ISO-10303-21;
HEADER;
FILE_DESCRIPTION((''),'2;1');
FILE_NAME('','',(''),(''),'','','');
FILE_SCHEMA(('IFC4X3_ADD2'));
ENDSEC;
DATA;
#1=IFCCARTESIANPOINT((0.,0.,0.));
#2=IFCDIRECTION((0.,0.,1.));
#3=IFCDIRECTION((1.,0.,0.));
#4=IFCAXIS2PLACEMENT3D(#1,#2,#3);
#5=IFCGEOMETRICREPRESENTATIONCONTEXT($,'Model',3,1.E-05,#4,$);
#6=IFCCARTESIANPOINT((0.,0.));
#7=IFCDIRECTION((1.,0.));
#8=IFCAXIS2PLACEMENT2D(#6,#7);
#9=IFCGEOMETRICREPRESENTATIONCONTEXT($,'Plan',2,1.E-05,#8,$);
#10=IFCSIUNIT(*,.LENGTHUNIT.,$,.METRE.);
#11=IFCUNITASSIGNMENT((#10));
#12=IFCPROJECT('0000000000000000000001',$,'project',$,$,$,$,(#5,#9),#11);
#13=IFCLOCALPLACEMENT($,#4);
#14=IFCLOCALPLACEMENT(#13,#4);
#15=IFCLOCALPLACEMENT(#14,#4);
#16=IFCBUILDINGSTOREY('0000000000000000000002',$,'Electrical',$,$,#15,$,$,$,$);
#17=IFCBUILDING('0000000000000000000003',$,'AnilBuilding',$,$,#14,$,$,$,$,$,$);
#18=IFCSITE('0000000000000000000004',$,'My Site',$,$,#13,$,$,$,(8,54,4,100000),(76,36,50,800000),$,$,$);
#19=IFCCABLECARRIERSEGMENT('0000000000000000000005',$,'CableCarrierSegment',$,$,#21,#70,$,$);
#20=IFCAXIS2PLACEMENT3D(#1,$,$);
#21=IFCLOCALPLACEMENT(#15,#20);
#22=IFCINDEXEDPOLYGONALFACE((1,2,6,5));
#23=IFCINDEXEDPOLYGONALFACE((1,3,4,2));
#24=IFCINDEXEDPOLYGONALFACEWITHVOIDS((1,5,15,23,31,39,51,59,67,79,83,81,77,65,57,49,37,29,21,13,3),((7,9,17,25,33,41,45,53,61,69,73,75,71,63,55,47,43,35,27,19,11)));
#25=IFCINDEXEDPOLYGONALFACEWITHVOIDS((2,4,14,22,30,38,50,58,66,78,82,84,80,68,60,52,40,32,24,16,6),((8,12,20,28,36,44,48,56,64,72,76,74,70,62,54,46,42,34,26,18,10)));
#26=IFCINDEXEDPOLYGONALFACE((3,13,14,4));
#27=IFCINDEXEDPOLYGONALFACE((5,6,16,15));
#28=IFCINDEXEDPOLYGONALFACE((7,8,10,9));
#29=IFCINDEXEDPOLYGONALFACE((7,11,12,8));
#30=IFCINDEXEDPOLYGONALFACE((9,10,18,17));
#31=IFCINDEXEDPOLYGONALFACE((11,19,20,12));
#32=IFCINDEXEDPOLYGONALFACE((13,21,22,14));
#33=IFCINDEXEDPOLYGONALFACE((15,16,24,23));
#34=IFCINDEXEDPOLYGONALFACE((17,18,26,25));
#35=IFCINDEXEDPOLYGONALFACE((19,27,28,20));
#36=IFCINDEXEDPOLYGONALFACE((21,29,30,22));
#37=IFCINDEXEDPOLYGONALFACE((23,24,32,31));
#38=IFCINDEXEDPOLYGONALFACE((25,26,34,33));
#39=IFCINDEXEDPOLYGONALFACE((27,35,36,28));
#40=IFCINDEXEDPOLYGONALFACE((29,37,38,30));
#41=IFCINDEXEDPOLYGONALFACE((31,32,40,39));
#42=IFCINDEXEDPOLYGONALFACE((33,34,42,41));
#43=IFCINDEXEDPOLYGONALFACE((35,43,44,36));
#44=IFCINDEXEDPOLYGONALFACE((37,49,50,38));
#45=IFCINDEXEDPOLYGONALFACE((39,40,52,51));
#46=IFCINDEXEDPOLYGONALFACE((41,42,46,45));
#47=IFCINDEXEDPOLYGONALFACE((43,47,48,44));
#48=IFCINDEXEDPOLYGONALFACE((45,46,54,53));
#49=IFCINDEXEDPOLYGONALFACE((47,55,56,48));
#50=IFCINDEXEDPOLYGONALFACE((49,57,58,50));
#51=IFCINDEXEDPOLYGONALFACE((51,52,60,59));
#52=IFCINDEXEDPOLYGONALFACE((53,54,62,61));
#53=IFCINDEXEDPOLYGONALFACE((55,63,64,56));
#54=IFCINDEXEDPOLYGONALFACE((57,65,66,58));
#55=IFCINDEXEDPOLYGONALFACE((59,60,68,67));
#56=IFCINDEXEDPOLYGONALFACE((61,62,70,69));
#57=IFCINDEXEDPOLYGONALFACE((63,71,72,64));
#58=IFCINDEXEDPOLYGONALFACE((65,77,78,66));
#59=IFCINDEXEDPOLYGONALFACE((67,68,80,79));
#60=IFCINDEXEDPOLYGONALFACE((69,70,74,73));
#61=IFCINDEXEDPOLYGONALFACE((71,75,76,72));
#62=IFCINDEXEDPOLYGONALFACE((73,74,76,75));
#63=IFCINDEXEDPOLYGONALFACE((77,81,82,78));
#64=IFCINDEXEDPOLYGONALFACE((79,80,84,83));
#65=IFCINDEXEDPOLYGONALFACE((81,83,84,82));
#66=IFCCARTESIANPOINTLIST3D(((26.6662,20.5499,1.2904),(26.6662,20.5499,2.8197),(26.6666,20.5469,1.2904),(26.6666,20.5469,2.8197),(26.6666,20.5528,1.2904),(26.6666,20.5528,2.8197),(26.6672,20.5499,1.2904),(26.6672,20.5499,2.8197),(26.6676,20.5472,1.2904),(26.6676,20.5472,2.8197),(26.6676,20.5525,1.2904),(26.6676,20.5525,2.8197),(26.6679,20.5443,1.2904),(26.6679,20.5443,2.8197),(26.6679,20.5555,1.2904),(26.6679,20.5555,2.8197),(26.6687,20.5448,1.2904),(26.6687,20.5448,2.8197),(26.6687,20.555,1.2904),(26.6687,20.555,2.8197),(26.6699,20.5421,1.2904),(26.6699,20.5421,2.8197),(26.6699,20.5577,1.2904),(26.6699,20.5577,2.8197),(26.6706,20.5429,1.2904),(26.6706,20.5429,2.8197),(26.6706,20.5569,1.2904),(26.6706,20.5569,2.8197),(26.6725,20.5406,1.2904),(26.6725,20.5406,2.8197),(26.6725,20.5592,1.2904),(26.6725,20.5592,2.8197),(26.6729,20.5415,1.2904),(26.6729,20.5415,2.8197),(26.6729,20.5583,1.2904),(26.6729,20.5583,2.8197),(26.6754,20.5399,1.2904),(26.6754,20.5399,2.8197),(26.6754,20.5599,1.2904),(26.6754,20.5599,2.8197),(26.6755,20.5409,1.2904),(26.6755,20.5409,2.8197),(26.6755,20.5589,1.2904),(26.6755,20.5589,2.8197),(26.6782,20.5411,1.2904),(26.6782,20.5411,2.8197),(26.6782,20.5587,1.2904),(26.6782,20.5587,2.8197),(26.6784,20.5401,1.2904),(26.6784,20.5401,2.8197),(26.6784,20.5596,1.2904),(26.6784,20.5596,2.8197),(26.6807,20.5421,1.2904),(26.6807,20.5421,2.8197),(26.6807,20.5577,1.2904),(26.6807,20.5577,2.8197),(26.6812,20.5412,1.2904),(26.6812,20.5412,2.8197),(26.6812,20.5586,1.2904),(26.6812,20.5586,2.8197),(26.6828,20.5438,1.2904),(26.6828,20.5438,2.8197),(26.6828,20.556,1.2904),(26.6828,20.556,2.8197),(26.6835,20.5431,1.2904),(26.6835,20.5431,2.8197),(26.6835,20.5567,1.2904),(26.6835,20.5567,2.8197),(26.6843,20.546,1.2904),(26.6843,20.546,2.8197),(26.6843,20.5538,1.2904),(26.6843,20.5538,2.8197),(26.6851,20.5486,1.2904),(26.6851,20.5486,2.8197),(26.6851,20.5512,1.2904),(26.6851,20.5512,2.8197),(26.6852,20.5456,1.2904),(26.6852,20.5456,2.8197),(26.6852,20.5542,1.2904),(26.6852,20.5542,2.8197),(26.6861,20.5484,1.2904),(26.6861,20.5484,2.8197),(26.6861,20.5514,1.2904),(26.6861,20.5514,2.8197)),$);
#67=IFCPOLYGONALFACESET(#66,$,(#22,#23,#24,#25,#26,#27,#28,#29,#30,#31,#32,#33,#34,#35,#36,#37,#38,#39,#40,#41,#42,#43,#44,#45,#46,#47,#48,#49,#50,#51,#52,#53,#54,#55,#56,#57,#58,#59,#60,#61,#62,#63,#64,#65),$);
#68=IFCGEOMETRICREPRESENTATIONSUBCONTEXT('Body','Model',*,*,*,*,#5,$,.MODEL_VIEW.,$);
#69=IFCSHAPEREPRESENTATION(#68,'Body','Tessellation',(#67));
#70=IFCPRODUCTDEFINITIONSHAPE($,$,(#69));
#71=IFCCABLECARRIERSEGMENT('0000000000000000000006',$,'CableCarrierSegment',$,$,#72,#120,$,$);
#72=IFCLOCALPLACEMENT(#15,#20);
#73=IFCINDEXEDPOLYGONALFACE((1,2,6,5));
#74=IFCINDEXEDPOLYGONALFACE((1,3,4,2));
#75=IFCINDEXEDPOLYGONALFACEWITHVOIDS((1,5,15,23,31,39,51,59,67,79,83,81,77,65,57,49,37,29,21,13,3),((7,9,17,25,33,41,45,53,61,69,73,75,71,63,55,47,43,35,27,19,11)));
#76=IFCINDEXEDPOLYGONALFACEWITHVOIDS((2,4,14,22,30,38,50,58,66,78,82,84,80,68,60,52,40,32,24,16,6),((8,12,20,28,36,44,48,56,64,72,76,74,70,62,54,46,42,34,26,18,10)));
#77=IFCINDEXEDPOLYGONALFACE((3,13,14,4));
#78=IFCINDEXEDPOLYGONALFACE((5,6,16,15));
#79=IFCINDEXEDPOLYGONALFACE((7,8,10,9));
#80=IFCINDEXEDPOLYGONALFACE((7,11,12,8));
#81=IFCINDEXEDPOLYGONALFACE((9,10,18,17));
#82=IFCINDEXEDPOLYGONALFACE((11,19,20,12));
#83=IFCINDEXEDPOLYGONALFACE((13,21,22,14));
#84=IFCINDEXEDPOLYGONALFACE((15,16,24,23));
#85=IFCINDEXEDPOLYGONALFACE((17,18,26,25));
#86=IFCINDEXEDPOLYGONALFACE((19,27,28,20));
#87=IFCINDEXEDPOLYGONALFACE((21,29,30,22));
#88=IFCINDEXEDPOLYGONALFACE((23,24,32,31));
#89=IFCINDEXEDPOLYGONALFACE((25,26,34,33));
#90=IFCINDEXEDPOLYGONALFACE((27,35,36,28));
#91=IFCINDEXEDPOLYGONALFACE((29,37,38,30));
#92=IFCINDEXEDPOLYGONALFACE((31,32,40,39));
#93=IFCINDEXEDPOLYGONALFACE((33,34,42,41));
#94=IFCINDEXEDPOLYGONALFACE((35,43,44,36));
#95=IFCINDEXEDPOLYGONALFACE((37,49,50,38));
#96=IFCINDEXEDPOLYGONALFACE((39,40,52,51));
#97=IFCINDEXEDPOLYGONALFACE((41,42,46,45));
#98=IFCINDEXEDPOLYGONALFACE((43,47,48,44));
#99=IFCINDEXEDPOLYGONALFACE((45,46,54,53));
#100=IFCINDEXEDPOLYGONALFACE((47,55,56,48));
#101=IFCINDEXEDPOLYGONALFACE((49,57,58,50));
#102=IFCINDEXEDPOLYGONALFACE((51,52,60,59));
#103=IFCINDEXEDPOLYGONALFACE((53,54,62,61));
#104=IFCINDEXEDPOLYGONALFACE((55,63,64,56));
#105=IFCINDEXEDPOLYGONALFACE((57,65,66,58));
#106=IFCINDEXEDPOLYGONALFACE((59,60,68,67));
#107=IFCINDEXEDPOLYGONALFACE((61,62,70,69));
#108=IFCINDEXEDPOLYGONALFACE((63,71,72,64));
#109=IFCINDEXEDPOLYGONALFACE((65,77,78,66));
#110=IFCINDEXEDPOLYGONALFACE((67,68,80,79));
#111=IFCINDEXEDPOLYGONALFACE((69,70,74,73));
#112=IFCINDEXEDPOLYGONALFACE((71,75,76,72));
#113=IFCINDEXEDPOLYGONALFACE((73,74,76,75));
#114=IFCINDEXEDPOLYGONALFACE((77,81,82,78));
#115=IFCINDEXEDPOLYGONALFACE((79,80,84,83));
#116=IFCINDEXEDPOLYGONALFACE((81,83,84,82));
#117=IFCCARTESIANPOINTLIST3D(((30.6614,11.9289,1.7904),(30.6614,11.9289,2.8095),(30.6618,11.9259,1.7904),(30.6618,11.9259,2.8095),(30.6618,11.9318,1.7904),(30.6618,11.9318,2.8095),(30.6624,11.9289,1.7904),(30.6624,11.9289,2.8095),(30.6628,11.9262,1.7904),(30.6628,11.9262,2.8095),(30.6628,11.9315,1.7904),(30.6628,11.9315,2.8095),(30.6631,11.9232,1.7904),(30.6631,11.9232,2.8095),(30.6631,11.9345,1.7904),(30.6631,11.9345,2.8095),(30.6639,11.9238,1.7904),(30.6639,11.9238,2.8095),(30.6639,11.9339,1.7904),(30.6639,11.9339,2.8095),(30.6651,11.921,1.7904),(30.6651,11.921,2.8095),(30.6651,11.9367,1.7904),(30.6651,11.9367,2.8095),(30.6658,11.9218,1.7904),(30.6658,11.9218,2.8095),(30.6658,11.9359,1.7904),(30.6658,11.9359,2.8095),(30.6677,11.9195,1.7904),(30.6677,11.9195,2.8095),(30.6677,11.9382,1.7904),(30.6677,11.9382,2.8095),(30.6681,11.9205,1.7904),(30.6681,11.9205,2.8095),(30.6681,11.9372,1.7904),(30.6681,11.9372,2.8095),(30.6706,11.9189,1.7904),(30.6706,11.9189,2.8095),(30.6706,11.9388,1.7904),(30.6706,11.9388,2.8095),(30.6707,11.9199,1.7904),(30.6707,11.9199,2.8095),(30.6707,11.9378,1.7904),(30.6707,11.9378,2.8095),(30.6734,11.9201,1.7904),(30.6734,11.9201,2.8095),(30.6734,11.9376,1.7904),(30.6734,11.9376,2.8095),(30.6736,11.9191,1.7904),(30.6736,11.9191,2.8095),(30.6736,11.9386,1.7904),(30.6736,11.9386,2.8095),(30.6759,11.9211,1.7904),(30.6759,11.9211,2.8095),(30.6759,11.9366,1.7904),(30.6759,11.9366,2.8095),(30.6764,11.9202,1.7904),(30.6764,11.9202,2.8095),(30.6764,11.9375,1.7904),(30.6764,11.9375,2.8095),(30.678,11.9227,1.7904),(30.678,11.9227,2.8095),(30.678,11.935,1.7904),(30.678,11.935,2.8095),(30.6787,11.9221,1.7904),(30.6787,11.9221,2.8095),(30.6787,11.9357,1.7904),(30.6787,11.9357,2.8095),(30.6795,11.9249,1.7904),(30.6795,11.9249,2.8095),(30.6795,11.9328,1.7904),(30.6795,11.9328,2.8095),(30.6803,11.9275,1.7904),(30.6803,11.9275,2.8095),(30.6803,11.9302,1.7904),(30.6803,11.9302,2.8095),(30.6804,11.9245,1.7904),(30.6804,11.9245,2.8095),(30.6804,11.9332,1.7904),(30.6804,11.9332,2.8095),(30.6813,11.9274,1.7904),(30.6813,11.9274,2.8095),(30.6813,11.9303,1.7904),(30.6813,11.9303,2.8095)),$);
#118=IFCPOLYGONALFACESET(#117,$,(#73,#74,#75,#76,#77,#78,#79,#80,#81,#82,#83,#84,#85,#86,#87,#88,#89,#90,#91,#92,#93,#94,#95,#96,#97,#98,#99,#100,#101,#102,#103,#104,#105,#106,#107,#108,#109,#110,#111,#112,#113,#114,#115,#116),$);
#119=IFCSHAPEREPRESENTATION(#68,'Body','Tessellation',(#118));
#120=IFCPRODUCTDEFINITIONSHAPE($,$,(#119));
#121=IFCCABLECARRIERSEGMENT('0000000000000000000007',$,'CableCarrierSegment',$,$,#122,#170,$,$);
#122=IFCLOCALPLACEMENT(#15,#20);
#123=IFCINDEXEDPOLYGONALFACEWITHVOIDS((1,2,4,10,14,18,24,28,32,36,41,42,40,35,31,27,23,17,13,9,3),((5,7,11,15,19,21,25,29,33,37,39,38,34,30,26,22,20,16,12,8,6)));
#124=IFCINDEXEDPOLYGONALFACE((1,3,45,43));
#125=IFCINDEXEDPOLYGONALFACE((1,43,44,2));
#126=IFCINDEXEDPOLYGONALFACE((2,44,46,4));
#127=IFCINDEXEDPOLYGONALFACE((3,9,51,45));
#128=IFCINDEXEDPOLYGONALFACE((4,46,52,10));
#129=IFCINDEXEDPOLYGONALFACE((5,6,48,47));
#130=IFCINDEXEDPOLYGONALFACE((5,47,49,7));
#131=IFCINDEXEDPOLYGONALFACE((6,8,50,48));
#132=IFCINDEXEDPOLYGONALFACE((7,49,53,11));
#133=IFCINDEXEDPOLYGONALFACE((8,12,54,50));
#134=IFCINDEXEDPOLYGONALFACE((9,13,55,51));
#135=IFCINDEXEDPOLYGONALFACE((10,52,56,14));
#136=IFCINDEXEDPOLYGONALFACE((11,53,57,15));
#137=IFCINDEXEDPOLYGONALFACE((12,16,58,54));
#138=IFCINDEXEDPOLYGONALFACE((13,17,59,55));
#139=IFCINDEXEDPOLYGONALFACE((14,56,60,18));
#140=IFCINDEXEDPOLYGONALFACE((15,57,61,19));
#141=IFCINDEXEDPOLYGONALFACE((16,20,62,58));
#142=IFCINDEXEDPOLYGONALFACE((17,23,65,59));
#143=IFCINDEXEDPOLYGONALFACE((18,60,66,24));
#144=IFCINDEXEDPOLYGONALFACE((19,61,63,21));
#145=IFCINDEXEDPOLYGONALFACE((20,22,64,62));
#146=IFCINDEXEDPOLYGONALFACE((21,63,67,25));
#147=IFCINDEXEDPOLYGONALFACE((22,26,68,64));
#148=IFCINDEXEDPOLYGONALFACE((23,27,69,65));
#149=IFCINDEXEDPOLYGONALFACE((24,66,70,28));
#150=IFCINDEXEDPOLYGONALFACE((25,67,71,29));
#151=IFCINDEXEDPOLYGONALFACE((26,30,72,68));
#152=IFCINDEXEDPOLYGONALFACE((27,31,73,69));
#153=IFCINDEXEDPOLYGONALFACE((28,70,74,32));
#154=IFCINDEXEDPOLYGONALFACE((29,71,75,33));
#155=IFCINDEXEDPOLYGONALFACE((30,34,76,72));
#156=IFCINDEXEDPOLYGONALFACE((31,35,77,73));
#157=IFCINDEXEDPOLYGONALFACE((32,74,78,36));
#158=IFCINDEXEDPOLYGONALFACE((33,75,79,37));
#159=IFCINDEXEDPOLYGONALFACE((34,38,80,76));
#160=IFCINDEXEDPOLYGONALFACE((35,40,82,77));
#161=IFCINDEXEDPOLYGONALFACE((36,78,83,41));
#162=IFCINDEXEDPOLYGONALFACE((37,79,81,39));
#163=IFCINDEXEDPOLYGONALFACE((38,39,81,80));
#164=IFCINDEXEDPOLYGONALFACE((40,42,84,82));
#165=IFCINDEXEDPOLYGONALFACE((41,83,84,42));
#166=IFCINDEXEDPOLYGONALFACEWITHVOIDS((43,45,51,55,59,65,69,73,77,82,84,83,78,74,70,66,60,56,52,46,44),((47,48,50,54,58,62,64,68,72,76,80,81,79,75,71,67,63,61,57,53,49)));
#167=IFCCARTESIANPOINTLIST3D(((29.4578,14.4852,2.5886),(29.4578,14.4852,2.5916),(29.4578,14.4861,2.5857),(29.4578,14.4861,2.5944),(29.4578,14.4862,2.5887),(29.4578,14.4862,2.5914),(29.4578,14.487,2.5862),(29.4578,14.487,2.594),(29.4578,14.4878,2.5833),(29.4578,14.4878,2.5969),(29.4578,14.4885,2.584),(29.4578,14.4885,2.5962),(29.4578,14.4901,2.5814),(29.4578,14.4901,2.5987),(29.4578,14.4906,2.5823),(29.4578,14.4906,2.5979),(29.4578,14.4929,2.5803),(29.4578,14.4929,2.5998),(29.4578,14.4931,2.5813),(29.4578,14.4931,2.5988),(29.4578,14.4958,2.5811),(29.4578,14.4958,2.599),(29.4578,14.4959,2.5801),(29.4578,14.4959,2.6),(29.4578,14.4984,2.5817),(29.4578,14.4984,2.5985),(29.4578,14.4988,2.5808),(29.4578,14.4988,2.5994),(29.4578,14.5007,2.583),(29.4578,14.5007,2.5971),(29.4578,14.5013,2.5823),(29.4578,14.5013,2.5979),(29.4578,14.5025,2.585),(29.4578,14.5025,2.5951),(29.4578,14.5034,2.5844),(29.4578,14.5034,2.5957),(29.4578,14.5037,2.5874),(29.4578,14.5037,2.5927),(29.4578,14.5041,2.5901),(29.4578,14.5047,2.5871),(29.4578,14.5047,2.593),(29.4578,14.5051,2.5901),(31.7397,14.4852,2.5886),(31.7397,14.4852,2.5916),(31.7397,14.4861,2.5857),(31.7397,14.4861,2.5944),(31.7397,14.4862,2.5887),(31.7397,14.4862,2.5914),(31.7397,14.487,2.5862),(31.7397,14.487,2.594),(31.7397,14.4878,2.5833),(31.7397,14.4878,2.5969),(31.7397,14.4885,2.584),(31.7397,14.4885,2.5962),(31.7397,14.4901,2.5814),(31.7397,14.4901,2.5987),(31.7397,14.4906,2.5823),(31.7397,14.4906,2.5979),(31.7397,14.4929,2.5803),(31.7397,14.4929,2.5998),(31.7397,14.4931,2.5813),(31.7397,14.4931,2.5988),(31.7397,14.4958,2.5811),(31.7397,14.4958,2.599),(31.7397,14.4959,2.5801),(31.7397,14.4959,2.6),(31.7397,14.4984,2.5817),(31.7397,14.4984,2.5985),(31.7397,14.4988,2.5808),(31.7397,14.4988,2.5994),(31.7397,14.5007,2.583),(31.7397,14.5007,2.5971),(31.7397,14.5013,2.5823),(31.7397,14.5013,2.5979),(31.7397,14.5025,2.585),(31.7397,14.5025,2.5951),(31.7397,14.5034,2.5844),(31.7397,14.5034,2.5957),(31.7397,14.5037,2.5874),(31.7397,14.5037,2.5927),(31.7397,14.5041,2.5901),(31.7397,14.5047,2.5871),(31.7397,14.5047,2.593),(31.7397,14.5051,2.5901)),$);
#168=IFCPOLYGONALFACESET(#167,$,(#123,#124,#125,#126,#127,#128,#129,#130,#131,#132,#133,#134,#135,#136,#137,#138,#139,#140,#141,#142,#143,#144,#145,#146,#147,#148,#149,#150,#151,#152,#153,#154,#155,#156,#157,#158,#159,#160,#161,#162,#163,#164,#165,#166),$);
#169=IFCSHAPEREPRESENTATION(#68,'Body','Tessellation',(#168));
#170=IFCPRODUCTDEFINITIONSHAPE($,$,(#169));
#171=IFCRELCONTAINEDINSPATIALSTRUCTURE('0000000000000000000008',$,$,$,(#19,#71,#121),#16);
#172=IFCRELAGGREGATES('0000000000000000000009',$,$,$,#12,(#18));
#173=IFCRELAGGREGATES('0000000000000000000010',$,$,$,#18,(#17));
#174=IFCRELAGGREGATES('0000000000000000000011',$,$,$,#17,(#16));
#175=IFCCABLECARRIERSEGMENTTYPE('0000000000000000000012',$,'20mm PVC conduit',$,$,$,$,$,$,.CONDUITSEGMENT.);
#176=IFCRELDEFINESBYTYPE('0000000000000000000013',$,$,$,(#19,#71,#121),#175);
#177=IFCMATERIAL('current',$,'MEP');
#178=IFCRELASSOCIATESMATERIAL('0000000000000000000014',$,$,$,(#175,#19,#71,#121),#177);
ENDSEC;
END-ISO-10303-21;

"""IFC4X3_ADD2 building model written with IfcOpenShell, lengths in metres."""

from ifc_helpers import new_model, si_unit, frame, origin_with_axes, origin_2d_with_axis, place, context, subcontext, project, spatial, hollow_circle, extrude, material, material_profile, profile_set, profile_usage, type_object, element, save


model = new_model("IFC4X3_ADD2")

# Units and contexts
model_context = context("Model", 3, precision=1e-05, world=origin_with_axes())
plan_context = context("Plan", 2, precision=1e-05, world=origin_2d_with_axis())
body_context = subcontext(model_context, "Body", "Model", "MODEL_VIEW")
ifc_project = project(units=[si_unit("LENGTHUNIT", "METRE")], contexts=[model_context, plan_context])

# Site, building, storey
site_placement = place(None, origin_with_axes())
site = spatial("IfcSite", under=ifc_project, at=site_placement, Name="My Site", RefLatitude=(8, 54, 4, 100000), RefLongitude=(76, 36, 50, 800000))
building_placement = place(site_placement, origin_with_axes())
building = spatial("IfcBuilding", under=site, at=building_placement, Name="AnilBuilding")
storey_placement = place(building_placement, origin_with_axes())
storey = spatial("IfcBuildingStorey", under=building, at=storey_placement, Name="Electrical")

# Cable carrier segments
ifc_material = material(Name="current", Category="MEP")
ifc_material_profile_1 = material_profile(ifc_material, hollow_circle(Radius=0.01, WallThickness=0.001))
ifc_profile_set_1 = profile_set([ifc_material_profile_1], Name="current")
ifc_material_profile_2 = material_profile(ifc_material, hollow_circle(Radius=0.01, WallThickness=0.001))
ifc_profile_set_2 = profile_set([ifc_material_profile_2], Name="current")
cable_carrier_segment_type = type_object("IfcCableCarrierSegmentType", Name="20mm PVC conduit", PredefinedType="CONDUITSEGMENT", material=ifc_profile_set_2)
ifc_profile_usage_1 = profile_usage(ifc_profile_set_1, cardinal=5)
cable_carrier_segment_1_placement = place(storey_placement, frame((26.6762, 20.5499, 1.2904), z_axis=(0.0, 0.0, 1.0), x_axis=(-1.0, 0.0, 0.0)))
element("IfcCableCarrierSegment", 1, at=cable_carrier_segment_1_placement, inside=storey, type_object=cable_carrier_segment_type, material=ifc_profile_usage_1, Name="CableCarrierSegment", context=body_context, shape_type="SweptSolid", body=[
    extrude(hollow_circle(Radius=0.01, WallThickness=0.001), origin_with_axes(), (0.0, 0.0, 1.0), 1.5293),
])
ifc_profile_usage_2 = profile_usage(ifc_profile_set_1, cardinal=5)
cable_carrier_segment_2_placement = place(storey_placement, frame((30.6714, 11.9289, 1.7904), z_axis=(0.0, 0.0, 1.0), x_axis=(-1.0, 0.0, 0.0)))
element("IfcCableCarrierSegment", 2, at=cable_carrier_segment_2_placement, inside=storey, type_object=cable_carrier_segment_type, material=ifc_profile_usage_2, Name="CableCarrierSegment", context=body_context, shape_type="SweptSolid", body=[
    extrude(hollow_circle(Radius=0.01, WallThickness=0.001), origin_with_axes(), (0.0, 0.0, 1.0), 1.0191),
])
ifc_profile_usage_3 = profile_usage(ifc_profile_set_1, cardinal=5)
cable_carrier_segment_3_placement = place(storey_placement, frame((29.4578, 14.4951, 2.5901), z_axis=(1.0, 0.0, 0.0), x_axis=(0.0, 1.0, 0.0)))
element("IfcCableCarrierSegment", 3, at=cable_carrier_segment_3_placement, inside=storey, type_object=cable_carrier_segment_type, material=ifc_profile_usage_3, Name="CableCarrierSegment", context=body_context, shape_type="SweptSolid", body=[
    extrude(hollow_circle(Radius=0.01, WallThickness=0.001), origin_with_axes(), (0.0, 0.0, 1.0), 2.282),
])

save(model, "model.ifc")
